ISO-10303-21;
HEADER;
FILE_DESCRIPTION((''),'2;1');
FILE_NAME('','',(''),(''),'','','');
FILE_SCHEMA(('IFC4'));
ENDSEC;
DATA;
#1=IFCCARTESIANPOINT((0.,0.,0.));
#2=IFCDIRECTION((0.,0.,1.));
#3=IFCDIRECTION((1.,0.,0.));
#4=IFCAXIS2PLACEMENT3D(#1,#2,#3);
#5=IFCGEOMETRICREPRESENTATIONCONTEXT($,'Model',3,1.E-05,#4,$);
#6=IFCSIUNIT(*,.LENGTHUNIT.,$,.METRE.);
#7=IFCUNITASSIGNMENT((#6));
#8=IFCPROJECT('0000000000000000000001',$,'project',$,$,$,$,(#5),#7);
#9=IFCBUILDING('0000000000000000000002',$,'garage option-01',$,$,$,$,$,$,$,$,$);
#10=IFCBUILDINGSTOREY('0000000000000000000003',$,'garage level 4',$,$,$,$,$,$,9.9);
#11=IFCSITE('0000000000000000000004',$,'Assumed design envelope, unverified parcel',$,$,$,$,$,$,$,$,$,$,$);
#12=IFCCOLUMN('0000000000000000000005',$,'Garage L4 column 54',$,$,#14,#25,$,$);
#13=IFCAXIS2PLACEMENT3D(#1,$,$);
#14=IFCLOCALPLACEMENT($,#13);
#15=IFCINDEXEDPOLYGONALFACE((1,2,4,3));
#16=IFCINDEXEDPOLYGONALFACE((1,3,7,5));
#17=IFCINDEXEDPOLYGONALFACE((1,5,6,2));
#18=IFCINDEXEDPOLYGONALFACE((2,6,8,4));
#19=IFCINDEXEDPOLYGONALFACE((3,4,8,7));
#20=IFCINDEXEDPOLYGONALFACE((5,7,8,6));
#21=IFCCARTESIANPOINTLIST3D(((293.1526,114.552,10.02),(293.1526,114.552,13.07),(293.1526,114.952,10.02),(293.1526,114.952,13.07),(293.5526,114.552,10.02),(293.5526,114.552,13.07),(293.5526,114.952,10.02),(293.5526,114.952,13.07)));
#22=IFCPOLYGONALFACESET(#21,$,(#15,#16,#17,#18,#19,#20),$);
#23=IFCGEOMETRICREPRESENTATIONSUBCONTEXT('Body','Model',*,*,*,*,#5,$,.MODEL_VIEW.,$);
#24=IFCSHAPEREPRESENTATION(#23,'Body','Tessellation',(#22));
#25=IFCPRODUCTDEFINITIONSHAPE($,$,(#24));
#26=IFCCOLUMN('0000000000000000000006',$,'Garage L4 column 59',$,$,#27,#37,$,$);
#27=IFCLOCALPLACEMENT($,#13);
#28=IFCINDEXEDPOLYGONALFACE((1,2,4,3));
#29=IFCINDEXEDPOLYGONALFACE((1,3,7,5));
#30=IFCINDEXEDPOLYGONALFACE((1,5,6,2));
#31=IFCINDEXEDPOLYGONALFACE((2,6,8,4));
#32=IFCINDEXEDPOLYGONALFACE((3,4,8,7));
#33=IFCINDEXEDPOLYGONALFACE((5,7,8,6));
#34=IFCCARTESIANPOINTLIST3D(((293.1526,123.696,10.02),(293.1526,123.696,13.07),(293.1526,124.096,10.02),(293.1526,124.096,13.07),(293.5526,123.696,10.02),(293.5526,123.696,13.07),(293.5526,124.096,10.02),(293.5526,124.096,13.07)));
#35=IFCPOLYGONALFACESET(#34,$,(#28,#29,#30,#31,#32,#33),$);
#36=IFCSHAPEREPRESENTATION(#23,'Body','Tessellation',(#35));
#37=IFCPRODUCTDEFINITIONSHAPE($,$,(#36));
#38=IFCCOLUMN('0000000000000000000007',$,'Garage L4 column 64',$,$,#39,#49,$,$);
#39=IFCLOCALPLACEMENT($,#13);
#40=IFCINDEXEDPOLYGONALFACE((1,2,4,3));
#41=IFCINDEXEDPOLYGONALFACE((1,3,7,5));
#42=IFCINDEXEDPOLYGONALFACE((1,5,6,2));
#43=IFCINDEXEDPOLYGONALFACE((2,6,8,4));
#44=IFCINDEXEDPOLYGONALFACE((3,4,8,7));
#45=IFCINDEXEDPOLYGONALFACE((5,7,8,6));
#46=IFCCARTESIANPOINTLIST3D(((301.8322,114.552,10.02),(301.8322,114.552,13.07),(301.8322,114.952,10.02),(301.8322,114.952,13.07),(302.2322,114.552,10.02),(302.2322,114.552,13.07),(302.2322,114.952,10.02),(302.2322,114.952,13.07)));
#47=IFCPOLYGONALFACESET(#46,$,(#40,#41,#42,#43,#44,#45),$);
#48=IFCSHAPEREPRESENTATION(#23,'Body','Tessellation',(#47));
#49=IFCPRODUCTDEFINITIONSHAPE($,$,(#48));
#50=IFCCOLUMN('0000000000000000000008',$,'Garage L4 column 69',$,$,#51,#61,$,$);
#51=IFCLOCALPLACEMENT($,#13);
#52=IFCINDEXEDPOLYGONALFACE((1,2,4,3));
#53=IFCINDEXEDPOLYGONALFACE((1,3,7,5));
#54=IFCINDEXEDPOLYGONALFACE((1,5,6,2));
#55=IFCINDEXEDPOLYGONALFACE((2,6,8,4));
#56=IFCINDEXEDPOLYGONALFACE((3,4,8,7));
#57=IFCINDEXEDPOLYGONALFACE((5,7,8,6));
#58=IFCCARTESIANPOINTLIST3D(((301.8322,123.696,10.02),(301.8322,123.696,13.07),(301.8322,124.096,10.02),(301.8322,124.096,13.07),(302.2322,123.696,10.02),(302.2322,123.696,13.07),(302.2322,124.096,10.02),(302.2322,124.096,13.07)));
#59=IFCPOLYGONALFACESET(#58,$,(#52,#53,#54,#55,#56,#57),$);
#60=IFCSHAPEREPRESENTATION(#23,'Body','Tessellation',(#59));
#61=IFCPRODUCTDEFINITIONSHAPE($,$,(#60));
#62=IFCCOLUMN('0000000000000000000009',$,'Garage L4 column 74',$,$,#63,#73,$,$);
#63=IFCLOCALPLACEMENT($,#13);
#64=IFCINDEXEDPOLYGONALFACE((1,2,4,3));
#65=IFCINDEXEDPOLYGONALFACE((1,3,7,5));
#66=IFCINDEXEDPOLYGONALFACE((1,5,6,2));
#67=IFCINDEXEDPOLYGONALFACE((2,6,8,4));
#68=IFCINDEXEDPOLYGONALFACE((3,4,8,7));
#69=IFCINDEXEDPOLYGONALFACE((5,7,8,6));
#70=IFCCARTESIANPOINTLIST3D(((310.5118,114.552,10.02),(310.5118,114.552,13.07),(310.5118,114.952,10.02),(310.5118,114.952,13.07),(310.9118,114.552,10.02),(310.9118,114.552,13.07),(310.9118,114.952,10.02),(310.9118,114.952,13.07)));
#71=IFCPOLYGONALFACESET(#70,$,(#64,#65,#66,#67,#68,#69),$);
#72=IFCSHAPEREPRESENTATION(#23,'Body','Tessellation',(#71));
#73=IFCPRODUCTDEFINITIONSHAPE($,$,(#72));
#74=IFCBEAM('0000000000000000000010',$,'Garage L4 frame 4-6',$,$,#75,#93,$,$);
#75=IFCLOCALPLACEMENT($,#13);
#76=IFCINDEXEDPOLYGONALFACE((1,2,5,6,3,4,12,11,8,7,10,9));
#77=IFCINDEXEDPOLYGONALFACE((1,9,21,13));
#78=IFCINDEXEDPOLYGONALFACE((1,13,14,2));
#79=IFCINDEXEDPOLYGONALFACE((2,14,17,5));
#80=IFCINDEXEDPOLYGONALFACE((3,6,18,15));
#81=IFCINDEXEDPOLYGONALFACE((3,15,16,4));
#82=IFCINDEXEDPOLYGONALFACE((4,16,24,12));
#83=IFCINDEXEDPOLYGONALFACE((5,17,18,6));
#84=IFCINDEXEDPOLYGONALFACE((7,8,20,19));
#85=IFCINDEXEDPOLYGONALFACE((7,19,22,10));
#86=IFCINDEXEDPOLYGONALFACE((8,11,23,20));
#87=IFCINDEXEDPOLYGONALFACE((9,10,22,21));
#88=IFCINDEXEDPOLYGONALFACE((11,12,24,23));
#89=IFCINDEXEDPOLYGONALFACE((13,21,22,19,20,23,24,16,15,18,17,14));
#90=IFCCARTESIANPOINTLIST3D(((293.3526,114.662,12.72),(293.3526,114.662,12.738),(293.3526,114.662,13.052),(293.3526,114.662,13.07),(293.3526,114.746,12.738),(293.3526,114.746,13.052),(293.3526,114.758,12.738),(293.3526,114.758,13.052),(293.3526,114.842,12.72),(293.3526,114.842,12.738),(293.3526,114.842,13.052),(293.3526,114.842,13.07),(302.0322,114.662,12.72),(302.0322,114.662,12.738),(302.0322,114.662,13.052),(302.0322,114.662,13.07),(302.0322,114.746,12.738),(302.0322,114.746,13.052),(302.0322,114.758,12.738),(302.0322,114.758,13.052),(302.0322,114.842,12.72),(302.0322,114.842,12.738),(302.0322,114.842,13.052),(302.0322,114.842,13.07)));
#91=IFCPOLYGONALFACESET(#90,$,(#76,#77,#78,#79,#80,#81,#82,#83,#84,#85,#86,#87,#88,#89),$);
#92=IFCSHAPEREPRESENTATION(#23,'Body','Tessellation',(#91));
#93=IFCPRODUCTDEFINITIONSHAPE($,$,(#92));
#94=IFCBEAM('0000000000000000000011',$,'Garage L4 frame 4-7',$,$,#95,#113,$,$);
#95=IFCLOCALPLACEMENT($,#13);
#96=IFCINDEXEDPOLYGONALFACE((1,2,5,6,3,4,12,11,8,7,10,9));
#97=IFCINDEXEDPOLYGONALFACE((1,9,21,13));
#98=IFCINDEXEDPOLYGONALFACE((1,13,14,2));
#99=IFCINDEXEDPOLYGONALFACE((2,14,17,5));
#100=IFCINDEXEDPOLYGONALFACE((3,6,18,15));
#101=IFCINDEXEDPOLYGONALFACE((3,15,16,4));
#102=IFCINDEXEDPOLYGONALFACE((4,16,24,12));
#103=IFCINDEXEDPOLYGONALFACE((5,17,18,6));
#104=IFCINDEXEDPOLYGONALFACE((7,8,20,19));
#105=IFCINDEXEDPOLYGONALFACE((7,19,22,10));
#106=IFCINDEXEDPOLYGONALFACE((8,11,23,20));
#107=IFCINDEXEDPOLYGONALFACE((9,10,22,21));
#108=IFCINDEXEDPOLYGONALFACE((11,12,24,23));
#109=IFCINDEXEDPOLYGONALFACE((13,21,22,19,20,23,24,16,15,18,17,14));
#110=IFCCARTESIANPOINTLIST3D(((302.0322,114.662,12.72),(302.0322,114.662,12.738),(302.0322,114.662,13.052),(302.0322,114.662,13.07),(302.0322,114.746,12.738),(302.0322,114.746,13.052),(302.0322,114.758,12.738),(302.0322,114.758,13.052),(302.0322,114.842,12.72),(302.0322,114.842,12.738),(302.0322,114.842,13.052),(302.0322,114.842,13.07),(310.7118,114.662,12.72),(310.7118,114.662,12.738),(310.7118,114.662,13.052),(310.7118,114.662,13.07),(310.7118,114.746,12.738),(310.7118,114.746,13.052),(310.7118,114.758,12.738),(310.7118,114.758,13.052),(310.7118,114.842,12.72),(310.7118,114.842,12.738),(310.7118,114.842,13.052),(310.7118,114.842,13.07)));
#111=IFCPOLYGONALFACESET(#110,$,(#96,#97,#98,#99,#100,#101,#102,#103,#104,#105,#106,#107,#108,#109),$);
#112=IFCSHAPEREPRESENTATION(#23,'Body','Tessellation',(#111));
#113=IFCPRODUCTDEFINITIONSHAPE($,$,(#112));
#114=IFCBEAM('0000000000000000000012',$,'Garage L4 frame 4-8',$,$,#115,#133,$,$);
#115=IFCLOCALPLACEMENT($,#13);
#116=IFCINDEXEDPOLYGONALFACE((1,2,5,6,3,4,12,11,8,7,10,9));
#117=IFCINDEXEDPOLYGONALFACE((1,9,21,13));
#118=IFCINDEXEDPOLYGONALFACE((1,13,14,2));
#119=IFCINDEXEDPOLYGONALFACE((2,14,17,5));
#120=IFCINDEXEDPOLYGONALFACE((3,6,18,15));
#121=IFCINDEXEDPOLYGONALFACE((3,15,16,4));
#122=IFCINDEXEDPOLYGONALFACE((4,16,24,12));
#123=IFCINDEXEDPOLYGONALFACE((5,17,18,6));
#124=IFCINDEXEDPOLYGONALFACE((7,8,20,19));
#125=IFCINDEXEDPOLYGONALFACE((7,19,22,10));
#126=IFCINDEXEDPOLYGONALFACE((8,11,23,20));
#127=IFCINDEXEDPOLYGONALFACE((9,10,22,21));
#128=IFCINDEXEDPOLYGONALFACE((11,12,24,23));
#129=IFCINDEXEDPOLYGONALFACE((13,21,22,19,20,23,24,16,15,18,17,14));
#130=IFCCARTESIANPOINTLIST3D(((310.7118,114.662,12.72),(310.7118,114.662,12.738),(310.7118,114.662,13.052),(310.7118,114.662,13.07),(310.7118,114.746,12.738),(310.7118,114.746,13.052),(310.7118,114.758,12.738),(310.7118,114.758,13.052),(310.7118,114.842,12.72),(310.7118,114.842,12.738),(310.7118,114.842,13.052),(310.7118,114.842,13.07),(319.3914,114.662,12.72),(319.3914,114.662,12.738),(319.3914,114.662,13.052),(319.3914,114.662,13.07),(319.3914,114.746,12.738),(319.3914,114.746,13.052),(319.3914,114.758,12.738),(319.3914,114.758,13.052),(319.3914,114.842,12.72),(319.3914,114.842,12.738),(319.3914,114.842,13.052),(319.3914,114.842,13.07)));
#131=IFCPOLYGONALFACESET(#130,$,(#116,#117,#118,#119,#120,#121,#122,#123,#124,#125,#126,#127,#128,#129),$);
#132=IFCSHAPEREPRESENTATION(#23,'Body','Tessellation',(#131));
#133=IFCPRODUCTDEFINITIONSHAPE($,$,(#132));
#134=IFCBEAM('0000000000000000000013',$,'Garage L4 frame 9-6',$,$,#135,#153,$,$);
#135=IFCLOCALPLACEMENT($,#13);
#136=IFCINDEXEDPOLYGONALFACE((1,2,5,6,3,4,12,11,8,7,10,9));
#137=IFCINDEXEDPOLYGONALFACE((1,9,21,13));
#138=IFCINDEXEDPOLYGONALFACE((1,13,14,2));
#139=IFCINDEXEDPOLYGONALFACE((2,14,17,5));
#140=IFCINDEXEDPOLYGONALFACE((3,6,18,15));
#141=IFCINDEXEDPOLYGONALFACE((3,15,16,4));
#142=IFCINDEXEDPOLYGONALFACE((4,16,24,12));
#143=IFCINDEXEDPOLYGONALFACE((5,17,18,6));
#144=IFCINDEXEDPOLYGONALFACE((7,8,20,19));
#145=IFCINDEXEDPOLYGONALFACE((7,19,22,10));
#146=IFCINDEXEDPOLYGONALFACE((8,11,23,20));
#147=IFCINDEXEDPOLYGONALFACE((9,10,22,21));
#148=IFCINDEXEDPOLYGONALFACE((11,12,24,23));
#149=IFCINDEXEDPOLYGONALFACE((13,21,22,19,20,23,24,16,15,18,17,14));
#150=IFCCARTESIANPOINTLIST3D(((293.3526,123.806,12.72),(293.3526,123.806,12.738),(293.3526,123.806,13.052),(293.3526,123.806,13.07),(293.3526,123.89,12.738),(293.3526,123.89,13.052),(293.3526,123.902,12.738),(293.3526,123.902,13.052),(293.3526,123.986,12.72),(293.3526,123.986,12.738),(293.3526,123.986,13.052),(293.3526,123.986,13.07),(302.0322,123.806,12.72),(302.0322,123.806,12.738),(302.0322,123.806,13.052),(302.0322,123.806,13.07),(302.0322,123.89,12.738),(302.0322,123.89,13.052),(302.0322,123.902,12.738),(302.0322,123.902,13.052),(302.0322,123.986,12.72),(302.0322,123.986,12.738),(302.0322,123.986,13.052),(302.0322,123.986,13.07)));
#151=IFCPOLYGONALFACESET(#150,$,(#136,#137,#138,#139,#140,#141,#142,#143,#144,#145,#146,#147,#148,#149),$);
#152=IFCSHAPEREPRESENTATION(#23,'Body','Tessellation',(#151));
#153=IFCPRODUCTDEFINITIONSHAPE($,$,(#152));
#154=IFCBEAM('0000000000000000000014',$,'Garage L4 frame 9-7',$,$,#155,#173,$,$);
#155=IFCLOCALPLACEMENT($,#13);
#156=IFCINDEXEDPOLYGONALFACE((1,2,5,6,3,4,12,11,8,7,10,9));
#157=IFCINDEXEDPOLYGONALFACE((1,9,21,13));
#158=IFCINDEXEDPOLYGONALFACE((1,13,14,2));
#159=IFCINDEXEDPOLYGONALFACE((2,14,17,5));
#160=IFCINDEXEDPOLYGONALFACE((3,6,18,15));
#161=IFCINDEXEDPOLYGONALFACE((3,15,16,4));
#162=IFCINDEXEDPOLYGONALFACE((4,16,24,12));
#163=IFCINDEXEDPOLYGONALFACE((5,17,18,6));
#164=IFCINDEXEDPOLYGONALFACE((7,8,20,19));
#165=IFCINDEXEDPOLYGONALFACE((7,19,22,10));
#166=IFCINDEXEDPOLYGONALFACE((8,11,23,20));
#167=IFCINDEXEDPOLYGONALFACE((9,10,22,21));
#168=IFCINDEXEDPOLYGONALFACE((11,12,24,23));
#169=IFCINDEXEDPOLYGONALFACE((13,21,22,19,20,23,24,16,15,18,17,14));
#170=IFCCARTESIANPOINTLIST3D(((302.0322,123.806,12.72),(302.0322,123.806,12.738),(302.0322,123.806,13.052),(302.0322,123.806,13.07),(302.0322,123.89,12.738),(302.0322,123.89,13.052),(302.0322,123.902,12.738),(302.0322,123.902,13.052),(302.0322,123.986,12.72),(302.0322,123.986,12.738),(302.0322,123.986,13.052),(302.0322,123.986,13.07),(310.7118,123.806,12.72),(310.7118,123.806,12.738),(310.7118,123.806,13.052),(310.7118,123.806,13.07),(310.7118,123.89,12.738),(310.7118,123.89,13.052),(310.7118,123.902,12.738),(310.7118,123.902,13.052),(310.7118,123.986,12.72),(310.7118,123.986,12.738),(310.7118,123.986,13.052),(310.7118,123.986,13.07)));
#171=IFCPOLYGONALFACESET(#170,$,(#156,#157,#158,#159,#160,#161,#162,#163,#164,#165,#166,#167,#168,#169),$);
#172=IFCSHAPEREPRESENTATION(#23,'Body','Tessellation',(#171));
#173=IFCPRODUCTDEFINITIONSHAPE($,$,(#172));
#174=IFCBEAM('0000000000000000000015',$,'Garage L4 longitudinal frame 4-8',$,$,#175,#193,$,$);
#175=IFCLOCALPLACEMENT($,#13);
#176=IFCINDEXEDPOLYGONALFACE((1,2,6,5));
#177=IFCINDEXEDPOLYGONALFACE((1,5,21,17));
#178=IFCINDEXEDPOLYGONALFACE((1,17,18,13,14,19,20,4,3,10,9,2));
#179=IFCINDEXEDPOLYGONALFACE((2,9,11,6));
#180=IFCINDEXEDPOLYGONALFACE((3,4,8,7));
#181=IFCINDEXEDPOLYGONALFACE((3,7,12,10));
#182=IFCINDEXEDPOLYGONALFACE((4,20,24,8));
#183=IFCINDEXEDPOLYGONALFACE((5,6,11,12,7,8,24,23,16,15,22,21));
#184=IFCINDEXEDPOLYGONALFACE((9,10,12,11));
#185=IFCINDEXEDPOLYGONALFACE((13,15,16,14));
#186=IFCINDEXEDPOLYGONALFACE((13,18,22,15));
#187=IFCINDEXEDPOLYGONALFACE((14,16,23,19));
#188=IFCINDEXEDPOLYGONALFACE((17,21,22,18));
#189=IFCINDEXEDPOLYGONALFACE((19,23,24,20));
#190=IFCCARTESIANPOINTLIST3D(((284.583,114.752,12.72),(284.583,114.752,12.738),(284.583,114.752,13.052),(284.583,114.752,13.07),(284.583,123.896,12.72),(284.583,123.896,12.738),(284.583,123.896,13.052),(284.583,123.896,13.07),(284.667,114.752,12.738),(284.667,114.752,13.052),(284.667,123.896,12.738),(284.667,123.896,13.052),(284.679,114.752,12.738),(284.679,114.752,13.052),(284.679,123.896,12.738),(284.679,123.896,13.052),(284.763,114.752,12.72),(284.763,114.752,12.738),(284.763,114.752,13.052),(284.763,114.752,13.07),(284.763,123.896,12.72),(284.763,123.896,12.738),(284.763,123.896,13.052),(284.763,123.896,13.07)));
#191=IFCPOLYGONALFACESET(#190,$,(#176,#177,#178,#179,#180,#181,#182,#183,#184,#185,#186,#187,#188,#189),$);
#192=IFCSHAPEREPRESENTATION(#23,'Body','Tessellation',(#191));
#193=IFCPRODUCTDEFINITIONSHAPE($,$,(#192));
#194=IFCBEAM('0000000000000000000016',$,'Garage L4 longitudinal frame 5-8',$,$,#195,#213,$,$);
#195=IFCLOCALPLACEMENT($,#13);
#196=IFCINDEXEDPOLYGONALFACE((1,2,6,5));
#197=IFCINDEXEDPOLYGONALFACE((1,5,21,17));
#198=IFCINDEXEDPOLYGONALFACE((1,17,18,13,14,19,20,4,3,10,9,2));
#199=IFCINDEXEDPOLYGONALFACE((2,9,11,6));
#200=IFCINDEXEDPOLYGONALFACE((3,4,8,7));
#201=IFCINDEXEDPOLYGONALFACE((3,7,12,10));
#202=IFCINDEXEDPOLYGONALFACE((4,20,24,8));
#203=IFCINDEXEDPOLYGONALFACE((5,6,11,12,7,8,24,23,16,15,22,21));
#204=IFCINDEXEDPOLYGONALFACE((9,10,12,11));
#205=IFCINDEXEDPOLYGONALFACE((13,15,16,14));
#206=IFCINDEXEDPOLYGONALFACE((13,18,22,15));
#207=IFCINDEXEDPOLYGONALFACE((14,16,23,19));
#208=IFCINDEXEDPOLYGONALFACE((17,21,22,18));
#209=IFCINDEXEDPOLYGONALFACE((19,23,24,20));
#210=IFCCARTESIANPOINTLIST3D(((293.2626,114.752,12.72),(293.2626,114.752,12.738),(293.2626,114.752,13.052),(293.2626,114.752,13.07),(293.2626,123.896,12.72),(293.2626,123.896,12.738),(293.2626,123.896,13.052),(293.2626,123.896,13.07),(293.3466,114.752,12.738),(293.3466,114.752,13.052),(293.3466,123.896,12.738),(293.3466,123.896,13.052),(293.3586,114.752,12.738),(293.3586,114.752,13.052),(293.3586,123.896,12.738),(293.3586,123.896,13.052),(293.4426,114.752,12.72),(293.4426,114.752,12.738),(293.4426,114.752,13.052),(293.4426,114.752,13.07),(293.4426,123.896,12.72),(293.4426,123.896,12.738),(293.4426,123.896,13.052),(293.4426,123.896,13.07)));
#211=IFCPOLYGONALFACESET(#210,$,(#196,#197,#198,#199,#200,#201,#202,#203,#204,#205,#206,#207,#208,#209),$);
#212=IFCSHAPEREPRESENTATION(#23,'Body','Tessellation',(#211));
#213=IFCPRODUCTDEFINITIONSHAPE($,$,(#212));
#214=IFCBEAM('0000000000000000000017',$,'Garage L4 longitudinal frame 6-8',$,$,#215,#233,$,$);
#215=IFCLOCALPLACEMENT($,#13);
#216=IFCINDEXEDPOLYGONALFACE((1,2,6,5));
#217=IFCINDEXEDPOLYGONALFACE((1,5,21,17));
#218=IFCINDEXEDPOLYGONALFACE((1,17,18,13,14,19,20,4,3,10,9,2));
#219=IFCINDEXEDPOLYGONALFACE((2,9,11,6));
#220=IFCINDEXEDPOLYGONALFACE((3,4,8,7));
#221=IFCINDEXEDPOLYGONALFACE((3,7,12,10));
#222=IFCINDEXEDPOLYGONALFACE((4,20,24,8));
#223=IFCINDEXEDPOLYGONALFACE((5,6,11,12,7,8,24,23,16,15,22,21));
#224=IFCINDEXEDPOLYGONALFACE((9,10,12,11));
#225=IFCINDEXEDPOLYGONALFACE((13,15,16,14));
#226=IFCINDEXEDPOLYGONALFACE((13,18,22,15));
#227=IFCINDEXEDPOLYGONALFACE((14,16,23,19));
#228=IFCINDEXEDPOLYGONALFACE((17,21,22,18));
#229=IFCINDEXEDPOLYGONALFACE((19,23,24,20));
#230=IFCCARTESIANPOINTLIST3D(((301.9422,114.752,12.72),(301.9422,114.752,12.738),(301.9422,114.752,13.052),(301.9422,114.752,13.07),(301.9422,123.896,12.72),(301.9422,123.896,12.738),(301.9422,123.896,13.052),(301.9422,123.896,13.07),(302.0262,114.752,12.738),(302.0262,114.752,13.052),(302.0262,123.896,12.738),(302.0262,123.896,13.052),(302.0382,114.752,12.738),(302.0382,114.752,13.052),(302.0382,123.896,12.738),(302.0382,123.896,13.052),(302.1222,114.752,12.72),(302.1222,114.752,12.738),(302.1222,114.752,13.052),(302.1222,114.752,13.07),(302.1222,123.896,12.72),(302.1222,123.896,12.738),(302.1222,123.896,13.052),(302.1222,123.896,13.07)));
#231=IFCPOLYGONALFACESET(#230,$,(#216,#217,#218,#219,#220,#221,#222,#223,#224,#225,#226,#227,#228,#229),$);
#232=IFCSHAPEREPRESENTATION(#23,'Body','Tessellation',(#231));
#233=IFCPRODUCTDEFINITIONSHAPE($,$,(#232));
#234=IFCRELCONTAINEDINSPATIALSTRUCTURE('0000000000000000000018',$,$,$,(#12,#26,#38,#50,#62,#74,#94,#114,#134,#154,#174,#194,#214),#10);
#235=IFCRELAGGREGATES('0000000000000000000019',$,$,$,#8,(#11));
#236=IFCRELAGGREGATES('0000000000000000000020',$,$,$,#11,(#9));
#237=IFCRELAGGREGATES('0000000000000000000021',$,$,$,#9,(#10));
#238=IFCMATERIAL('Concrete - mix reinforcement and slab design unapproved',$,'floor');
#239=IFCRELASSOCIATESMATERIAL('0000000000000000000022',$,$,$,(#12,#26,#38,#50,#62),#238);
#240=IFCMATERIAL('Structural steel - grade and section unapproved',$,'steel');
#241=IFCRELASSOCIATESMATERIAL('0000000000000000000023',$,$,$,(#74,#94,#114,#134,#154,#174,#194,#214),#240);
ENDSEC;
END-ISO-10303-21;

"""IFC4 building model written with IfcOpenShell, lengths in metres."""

from ifc_helpers import new_model, si_unit, frame, origin_with_axes, place, context, subcontext, project, spatial, rectangle, i_section, extrude, material, element, save


model = new_model("IFC4")

# Units and contexts
model_context = context("Model", 3, precision=1e-05, world=origin_with_axes())
body_context = subcontext(model_context, "Body", "Model", "MODEL_VIEW")
ifc_project = project(units=[si_unit("LENGTHUNIT", "METRE")], contexts=[model_context])

# Site, building, storey
site = spatial("IfcSite", under=ifc_project, Name="Assumed design envelope, unverified parcel")
building = spatial("IfcBuilding", under=site, Name="garage option-01")
storey = spatial("IfcBuildingStorey", under=building, Name="garage level 4", Elevation=9.9)

# Columns
ifc_material_1 = material(Name="Concrete - mix reinforcement and slab design unapproved", Category="floor")
for number, where, z_axis, x_axis, name in (
    (1, (293.3526, 114.752, 10.02), (0.0, 0.0, 1.0), (1.0, 0.0, 0.0), "Garage L4 column 54"),
    (2, (293.3526, 123.896, 10.02), (0.0, 0.0, 1.0), (1.0, 0.0, 0.0), "Garage L4 column 59"),
    (3, (302.0322, 114.752, 10.02), (0.0, 0.0, 1.0), (1.0, 0.0, 0.0), "Garage L4 column 64"),
    (4, (302.0322, 123.896, 10.02), (0.0, 0.0, 1.0), (1.0, 0.0, 0.0), "Garage L4 column 69"),
    (5, (310.7118, 114.752, 10.02), (0.0, 0.0, 1.0), (1.0, 0.0, 0.0), "Garage L4 column 74"),
):
    element("IfcColumn", number, at=place(None, frame(where, z_axis=z_axis, x_axis=x_axis)), inside=storey, material=ifc_material_1, Name=name, context=body_context, shape_type="SweptSolid", body=[
        extrude(rectangle(XDim=0.4, YDim=0.4), origin_with_axes(), (0.0, 0.0, 1.0), 3.05),
    ])

# Beams
ifc_material_2 = material(Name="Structural steel - grade and section unapproved", Category="steel")
for number, where, z_axis, x_axis, name in (
    (6, (293.3526, 114.752, 12.895), (1.0, 0.0, 0.0), (0.0, 1.0, 0.0), "Garage L4 frame 4-6"),
    (7, (302.0322, 114.752, 12.895), (1.0, 0.0, 0.0), (0.0, 1.0, 0.0), "Garage L4 frame 4-7"),
    (8, (310.7118, 114.752, 12.895), (1.0, 0.0, 0.0), (0.0, 1.0, 0.0), "Garage L4 frame 4-8"),
    (9, (293.3526, 123.896, 12.895), (1.0, 0.0, 0.0), (0.0, 1.0, 0.0), "Garage L4 frame 9-6"),
    (10, (302.0322, 123.896, 12.895), (1.0, 0.0, 0.0), (0.0, 1.0, 0.0), "Garage L4 frame 9-7"),
):
    element("IfcBeam", number, at=place(None, frame(where, z_axis=z_axis, x_axis=x_axis)), inside=storey, material=ifc_material_2, Name=name, context=body_context, shape_type="SweptSolid", body=[
        extrude(i_section(OverallWidth=0.18, OverallDepth=0.35, WebThickness=0.012, FlangeThickness=0.018, FilletRadius=0.0), origin_with_axes(), (0.0, 0.0, 1.0), 8.6796),
    ])
for number, where, z_axis, x_axis, name in (
    (11, (284.673, 114.752, 12.895), (0.0, 1.0, 0.0), (-1.0, 0.0, 0.0), "Garage L4 longitudinal frame 4-8"),
    (12, (293.3526, 114.752, 12.895), (0.0, 1.0, 0.0), (-1.0, 0.0, 0.0), "Garage L4 longitudinal frame 5-8"),
    (13, (302.0322, 114.752, 12.895), (0.0, 1.0, 0.0), (-1.0, 0.0, 0.0), "Garage L4 longitudinal frame 6-8"),
):
    element("IfcBeam", number, at=place(None, frame(where, z_axis=z_axis, x_axis=x_axis)), inside=storey, material=ifc_material_2, Name=name, context=body_context, shape_type="SweptSolid", body=[
        extrude(i_section(OverallWidth=0.18, OverallDepth=0.35, WebThickness=0.012, FlangeThickness=0.018, FilletRadius=0.0), origin_with_axes(), (0.0, 0.0, 1.0), 9.144),
    ])

save(model, "model.ifc")
